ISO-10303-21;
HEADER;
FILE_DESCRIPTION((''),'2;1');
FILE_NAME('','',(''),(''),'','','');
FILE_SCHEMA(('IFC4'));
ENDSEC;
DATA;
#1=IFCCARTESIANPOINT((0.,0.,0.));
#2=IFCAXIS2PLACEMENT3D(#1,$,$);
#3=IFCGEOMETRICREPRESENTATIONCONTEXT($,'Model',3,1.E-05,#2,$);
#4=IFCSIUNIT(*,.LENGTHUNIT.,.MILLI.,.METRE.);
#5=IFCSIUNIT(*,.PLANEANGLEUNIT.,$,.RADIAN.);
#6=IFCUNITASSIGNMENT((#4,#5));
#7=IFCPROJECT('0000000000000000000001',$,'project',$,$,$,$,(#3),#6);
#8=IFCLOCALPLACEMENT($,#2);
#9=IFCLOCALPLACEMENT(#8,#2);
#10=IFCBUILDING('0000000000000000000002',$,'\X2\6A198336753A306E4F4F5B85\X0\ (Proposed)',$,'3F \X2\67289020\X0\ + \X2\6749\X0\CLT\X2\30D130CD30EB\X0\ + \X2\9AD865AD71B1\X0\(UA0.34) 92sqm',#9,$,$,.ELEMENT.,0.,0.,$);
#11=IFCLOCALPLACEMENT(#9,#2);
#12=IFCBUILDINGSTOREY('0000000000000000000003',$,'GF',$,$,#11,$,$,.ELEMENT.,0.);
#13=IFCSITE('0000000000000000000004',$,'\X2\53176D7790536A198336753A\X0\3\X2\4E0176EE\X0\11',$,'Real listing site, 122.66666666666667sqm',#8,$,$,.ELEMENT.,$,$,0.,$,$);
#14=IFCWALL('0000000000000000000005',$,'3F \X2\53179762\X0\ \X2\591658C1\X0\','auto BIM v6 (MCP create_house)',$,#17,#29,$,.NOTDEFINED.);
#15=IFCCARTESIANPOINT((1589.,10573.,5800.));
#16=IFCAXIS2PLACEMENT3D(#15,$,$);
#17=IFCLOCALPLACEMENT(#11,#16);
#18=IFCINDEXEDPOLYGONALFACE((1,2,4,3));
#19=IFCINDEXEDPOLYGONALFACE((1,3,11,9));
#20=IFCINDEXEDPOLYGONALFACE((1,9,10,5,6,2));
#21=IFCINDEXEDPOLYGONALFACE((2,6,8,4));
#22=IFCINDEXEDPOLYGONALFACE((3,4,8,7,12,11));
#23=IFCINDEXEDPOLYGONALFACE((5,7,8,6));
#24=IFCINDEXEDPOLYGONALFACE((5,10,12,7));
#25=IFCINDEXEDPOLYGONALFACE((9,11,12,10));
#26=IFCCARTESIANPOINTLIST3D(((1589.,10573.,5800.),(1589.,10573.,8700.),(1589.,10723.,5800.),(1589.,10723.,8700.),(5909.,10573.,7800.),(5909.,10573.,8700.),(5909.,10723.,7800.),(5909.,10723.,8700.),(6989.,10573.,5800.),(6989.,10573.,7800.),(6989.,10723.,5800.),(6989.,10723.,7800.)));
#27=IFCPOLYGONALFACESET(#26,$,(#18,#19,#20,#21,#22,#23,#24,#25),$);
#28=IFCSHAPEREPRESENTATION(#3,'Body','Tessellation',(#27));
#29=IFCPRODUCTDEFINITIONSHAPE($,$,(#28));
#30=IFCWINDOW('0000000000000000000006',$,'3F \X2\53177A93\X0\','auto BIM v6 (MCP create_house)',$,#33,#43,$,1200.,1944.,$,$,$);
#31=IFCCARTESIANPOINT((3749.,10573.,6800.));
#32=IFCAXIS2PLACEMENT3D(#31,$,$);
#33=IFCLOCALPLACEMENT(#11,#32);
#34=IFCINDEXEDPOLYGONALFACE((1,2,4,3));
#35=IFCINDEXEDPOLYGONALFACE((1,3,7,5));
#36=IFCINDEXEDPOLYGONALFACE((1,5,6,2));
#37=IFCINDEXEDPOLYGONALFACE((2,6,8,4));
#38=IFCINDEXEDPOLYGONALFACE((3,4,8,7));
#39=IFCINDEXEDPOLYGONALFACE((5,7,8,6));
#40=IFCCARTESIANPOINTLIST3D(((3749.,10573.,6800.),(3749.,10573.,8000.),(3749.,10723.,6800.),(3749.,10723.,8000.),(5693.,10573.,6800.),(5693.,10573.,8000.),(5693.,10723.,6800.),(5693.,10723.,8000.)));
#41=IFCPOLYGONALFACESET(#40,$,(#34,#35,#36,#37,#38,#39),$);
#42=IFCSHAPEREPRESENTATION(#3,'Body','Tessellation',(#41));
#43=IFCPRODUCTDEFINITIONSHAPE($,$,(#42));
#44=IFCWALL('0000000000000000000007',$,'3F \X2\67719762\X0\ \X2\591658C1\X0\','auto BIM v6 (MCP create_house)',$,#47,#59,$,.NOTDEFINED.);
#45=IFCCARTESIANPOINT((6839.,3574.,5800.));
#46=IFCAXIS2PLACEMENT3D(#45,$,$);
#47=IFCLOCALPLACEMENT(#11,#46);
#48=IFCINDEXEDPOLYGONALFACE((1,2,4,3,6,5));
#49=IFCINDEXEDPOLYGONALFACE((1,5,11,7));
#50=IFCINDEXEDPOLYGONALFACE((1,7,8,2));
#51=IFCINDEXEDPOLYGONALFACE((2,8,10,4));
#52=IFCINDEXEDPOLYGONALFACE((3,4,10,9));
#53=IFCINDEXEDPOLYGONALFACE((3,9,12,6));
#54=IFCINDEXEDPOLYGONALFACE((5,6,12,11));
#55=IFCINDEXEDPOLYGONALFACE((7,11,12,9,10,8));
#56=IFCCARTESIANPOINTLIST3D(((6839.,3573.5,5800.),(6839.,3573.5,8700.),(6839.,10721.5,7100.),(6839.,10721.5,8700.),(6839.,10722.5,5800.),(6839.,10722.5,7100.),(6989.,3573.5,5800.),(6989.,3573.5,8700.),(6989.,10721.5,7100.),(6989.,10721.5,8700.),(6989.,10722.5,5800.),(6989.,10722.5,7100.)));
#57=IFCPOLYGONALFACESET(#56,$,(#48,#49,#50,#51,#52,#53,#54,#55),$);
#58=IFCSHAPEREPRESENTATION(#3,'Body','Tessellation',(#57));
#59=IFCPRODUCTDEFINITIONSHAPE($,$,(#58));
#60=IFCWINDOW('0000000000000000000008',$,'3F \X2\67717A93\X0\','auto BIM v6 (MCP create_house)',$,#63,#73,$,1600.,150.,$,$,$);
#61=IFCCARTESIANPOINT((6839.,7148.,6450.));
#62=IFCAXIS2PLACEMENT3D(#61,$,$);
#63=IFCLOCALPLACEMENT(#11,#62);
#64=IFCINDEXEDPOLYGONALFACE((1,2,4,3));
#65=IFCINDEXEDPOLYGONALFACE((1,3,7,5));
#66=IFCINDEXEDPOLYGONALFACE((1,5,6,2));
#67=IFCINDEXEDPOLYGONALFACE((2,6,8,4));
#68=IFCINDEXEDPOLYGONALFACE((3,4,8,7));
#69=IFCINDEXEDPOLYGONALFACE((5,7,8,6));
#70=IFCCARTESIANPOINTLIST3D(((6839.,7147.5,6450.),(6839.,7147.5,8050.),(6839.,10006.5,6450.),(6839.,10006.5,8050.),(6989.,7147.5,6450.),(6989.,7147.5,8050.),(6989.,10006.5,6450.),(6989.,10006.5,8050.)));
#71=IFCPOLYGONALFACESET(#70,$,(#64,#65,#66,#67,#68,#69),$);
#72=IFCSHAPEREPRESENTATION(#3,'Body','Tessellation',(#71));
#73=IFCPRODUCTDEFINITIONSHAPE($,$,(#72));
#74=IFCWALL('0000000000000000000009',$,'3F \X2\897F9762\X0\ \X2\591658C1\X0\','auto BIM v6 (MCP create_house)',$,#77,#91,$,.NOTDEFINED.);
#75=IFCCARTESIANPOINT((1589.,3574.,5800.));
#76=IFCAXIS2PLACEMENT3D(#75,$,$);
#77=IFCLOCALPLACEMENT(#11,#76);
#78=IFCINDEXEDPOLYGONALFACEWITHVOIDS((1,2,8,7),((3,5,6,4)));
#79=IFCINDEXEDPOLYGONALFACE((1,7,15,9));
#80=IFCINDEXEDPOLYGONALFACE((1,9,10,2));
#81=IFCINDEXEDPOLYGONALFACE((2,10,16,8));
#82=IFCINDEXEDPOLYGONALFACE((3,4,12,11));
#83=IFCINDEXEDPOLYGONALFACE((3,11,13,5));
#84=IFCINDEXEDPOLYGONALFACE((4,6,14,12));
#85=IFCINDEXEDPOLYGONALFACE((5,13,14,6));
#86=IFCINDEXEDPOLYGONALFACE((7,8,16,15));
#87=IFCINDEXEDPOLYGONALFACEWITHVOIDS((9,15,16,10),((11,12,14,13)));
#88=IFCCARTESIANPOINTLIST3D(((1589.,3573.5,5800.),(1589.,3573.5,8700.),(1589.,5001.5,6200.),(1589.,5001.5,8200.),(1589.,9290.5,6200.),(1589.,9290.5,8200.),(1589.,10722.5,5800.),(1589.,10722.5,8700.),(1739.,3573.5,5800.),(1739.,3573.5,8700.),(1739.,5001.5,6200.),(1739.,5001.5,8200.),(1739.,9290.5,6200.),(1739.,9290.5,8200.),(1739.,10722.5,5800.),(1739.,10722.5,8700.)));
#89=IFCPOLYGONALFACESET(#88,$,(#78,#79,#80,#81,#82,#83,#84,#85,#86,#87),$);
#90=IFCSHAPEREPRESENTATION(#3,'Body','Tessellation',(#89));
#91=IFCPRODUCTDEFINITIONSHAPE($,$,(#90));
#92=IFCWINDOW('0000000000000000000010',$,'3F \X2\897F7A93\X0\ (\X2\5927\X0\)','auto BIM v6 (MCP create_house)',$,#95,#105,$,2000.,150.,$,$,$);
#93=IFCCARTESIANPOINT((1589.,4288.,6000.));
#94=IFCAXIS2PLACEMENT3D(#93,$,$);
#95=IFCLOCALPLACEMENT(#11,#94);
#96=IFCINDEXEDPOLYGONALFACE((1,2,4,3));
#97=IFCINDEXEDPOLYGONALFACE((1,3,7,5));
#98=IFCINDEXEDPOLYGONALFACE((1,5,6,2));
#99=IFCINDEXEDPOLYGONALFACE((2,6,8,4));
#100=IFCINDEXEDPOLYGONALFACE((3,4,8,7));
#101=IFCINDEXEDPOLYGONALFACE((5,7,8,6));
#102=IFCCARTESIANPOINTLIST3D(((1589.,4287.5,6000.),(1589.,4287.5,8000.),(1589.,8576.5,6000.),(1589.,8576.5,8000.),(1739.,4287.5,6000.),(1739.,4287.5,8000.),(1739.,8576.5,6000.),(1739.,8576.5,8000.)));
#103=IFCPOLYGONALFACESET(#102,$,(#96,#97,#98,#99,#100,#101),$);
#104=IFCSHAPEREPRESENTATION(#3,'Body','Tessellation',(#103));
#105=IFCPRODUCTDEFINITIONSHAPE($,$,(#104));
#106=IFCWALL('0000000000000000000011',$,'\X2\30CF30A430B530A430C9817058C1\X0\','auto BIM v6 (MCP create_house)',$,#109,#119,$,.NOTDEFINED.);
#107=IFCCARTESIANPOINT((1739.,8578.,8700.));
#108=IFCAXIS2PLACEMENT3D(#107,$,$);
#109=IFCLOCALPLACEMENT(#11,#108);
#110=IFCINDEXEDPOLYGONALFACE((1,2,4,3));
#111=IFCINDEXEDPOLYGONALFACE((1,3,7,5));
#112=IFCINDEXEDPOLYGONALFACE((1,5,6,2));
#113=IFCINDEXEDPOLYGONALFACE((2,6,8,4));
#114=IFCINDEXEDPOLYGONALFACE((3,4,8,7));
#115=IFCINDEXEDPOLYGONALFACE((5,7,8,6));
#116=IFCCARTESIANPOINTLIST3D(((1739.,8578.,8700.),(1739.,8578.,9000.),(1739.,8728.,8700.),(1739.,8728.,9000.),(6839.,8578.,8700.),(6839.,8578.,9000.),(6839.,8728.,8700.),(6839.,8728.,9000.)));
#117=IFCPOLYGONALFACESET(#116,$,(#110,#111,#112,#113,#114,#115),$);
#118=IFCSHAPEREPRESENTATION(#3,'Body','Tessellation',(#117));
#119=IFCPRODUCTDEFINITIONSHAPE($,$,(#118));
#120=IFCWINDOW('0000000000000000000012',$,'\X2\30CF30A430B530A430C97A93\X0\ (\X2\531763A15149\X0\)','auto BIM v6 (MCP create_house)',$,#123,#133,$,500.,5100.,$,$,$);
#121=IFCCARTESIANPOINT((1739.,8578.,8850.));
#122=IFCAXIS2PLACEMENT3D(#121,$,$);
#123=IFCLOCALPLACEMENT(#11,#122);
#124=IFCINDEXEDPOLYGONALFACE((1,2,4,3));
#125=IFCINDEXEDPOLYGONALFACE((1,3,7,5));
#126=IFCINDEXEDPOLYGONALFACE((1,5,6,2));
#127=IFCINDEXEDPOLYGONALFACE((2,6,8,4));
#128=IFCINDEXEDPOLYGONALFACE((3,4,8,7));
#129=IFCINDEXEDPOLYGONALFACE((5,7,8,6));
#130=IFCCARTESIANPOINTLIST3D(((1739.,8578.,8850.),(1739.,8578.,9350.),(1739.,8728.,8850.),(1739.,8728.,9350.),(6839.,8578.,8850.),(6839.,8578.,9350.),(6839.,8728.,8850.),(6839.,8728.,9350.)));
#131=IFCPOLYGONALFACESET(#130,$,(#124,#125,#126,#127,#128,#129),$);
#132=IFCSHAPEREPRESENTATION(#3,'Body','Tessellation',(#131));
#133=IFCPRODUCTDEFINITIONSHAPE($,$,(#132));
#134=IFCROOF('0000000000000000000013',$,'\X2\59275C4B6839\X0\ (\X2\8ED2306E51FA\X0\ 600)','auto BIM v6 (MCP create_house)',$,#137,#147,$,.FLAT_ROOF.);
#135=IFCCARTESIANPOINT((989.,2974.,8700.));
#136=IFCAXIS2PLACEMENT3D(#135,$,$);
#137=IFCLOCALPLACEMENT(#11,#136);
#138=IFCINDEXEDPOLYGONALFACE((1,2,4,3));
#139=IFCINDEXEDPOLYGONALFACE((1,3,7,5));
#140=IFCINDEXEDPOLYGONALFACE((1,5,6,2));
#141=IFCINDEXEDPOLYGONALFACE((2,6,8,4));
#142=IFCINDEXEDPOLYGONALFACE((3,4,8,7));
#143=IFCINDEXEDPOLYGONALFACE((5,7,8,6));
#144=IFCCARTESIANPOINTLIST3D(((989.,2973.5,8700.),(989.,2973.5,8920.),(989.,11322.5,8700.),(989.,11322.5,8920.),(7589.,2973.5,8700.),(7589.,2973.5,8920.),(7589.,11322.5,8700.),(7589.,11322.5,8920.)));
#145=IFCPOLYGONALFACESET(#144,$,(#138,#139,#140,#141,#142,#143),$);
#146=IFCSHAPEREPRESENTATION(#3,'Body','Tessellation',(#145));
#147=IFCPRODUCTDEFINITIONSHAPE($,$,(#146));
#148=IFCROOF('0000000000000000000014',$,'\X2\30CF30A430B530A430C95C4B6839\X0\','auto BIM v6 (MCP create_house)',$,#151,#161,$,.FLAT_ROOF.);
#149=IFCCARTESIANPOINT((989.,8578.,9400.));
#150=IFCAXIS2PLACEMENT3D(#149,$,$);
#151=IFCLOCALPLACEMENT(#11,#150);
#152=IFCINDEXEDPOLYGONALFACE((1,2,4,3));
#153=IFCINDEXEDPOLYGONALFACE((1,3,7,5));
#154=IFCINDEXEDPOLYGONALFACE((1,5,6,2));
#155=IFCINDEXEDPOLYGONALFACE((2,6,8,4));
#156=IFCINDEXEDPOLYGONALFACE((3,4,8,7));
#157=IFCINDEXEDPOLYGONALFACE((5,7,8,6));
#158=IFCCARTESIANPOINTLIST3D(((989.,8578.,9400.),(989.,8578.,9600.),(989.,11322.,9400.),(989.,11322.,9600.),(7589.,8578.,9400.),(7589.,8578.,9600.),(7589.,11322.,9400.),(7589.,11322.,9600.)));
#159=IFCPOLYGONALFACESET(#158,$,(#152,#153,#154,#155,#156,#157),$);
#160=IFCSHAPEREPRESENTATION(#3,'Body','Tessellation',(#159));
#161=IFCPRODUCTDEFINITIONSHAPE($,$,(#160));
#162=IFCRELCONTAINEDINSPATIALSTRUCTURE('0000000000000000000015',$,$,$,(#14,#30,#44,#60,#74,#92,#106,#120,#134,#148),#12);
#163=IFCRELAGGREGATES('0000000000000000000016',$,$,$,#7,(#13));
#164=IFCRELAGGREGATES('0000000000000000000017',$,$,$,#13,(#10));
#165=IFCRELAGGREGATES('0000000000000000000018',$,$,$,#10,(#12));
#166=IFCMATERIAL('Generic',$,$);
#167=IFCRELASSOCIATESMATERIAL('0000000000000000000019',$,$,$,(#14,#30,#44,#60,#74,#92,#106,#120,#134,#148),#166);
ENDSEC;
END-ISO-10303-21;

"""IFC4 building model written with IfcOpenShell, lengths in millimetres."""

from ifc_helpers import new_model, si_unit, frame, frame_2d, origin, place, context, project, spatial, rectangle, extrude, material, element, fill, save


model = new_model("IFC4")

# Units and contexts
model_context = context("Model", 3, precision=1e-05, world=origin())
ifc_project = project(units=[si_unit("LENGTHUNIT", "METRE", prefix="MILLI"), si_unit("PLANEANGLEUNIT", "RADIAN")], contexts=[model_context])

# Site, building, storey
site_placement = place(None, origin())
site = spatial("IfcSite", under=ifc_project, at=site_placement, Name="北海道標茶町3丁目11", ObjectType="Real listing site, 122.66666666666667sqm", CompositionType="ELEMENT", RefElevation=0.0)
building_placement = place(site_placement, origin())
building = spatial("IfcBuilding", under=site, at=building_placement, Name="標茶町の住宅 (Proposed)", ObjectType="3F 木造 + 杉CLTパネル + 高断熱(UA0.34) 92sqm", CompositionType="ELEMENT", ElevationOfRefHeight=0.0, ElevationOfTerrain=0.0)
storey_placement = place(building_placement, origin())
storey = spatial("IfcBuildingStorey", under=building, at=storey_placement, Name="GF", CompositionType="ELEMENT", Elevation=0.0)

# Shared definitions
ifc_material = material(Name="Generic")

# Walls, openings, windows
wall_1_placement = place(storey_placement, frame((1589.0, 10573.0, 5800.0)))
wall_1 = element("IfcWall", 1, at=wall_1_placement, inside=storey, material=ifc_material, Name="3F 北面 外壁", Description="auto BIM v6 (MCP create_house)", PredefinedType="NOTDEFINED", context=model_context, shape_type="SweptSolid", body=[
    extrude(rectangle(XDim=5400.0, YDim=150.0, at=frame_2d((2700.0, 75.0))), frame((1589.0, 10573.0, 5800.0)), (0.0, 0.0, 1.0), 2900.0),
])
opening_1_placement = place(storey_placement, frame((3749.0, 10573.0, 6800.0)))
opening_1 = element("IfcOpeningElement", 2, at=opening_1_placement, cuts=wall_1, PredefinedType="NOTDEFINED", context=model_context, shape_type="SweptSolid", body=[
    extrude(rectangle(XDim=1944.0, YDim=150.0, at=frame_2d((972.0, 75.0))), frame((3749.0, 10573.0, 6800.0)), (0.0, 0.0, 1.0), 1200.0),
])
window_1_placement = place(storey_placement, frame((3749.0, 10573.0, 6800.0)))
window_1 = element("IfcWindow", 3, at=window_1_placement, inside=storey, material=ifc_material, Name="3F 北窓", Description="auto BIM v6 (MCP create_house)", OverallHeight=1200.0, OverallWidth=1944.0, context=model_context, shape_type="SweptSolid", body=[
    extrude(rectangle(XDim=1944.0, YDim=150.0, at=frame_2d((972.0, 75.0))), frame((3749.0, 10573.0, 6800.0)), (0.0, 0.0, 1.0), 1200.0),
])
fill(opening_1, window_1)
wall_2_placement = place(storey_placement, frame((6839.0, 3574.0, 5800.0)))
wall_2 = element("IfcWall", 4, at=wall_2_placement, inside=storey, material=ifc_material, Name="3F 東面 外壁", Description="auto BIM v6 (MCP create_house)", PredefinedType="NOTDEFINED", context=model_context, shape_type="SweptSolid", body=[
    extrude(rectangle(XDim=150.0, YDim=7149.0, at=frame_2d((75.0, 3574.0))), frame((6839.0, 3574.0, 5800.0)), (0.0, 0.0, 1.0), 2900.0),
])
opening_2_placement = place(storey_placement, frame((6839.0, 7148.0, 6450.0)))
opening_2 = element("IfcOpeningElement", 5, at=opening_2_placement, cuts=wall_2, PredefinedType="NOTDEFINED", context=model_context, shape_type="SweptSolid", body=[
    extrude(rectangle(XDim=150.0, YDim=2859.0, at=frame_2d((75.0, 1429.0))), frame((6839.0, 7148.0, 6450.0)), (0.0, 0.0, 1.0), 1600.0),
])
window_2_placement = place(storey_placement, frame((6839.0, 7148.0, 6450.0)))
window_2 = element("IfcWindow", 6, at=window_2_placement, inside=storey, material=ifc_material, Name="3F 東窓", Description="auto BIM v6 (MCP create_house)", OverallHeight=1600.0, OverallWidth=150.0, context=model_context, shape_type="SweptSolid", body=[
    extrude(rectangle(XDim=150.0, YDim=2859.0, at=frame_2d((75.0, 1429.0))), frame((6839.0, 7148.0, 6450.0)), (0.0, 0.0, 1.0), 1600.0),
])
fill(opening_2, window_2)
wall_3_placement = place(storey_placement, frame((1589.0, 3574.0, 5800.0)))
wall_3 = element("IfcWall", 7, at=wall_3_placement, inside=storey, material=ifc_material, Name="3F 西面 外壁", Description="auto BIM v6 (MCP create_house)", PredefinedType="NOTDEFINED", context=model_context, shape_type="SweptSolid", body=[
    extrude(rectangle(XDim=150.0, YDim=7149.0, at=frame_2d((75.0, 3574.0))), frame((1589.0, 3574.0, 5800.0)), (0.0, 0.0, 1.0), 2900.0),
])
opening_3_placement = place(storey_placement, frame((1589.0, 4288.0, 6000.0)))
opening_3 = element("IfcOpeningElement", 8, at=opening_3_placement, cuts=wall_3, PredefinedType="NOTDEFINED", context=model_context, shape_type="SweptSolid", body=[
    extrude(rectangle(XDim=150.0, YDim=4289.0, at=frame_2d((75.0, 2144.0))), frame((1589.0, 4288.0, 6000.0)), (0.0, 0.0, 1.0), 2000.0),
])
window_3_placement = place(storey_placement, frame((1589.0, 4288.0, 6000.0)))
window_3 = element("IfcWindow", 9, at=window_3_placement, inside=storey, material=ifc_material, Name="3F 西窓 (大)", Description="auto BIM v6 (MCP create_house)", OverallHeight=2000.0, OverallWidth=150.0, context=model_context, shape_type="SweptSolid", body=[
    extrude(rectangle(XDim=150.0, YDim=4289.0, at=frame_2d((75.0, 2144.0))), frame((1589.0, 4288.0, 6000.0)), (0.0, 0.0, 1.0), 2000.0),
])
fill(opening_3, window_3)

# Wall, opening, window
wall_4_placement = place(storey_placement, frame((1739.0, 8578.0, 8700.0)))
wall_4 = element("IfcWall", 10, at=wall_4_placement, inside=storey, material=ifc_material, Name="ハイサイド腰壁", Description="auto BIM v6 (MCP create_house)", PredefinedType="NOTDEFINED", context=model_context, shape_type="SweptSolid", body=[
    extrude(rectangle(XDim=5100.0, YDim=150.0, at=frame_2d((2550.0, 75.0))), frame((1739.0, 8578.0, 8700.0)), (0.0, 0.0, 1.0), 700.0),
])
opening_4_placement = place(storey_placement, frame((1739.0, 8578.0, 8850.0)))
opening_4 = element("IfcOpeningElement", 11, at=opening_4_placement, cuts=wall_4, PredefinedType="NOTDEFINED", context=model_context, shape_type="SweptSolid", body=[
    extrude(rectangle(XDim=5100.0, YDim=150.0, at=frame_2d((2550.0, 75.0))), frame((1739.0, 8578.0, 8850.0)), (0.0, 0.0, 1.0), 500.0),
])
window_4_placement = place(storey_placement, frame((1739.0, 8578.0, 8850.0)))
window_4 = element("IfcWindow", 12, at=window_4_placement, inside=storey, material=ifc_material, Name="ハイサイド窓 (北採光)", Description="auto BIM v6 (MCP create_house)", OverallHeight=500.0, OverallWidth=5100.0, context=model_context, shape_type="SweptSolid", body=[
    extrude(rectangle(XDim=5100.0, YDim=150.0, at=frame_2d((2550.0, 75.0))), frame((1739.0, 8578.0, 8850.0)), (0.0, 0.0, 1.0), 500.0),
])
fill(opening_4, window_4)

# Roofs
roof_1_placement = place(storey_placement, frame((989.0, 2974.0, 8700.0)))
element("IfcRoof", 13, at=roof_1_placement, inside=storey, material=ifc_material, Name="大屋根 (軒の出 600)", Description="auto BIM v6 (MCP create_house)", PredefinedType="FLAT_ROOF", context=model_context, shape_type="SweptSolid", body=[
    extrude(rectangle(XDim=6600.0, YDim=8349.0, at=frame_2d((3300.0, 4174.0))), frame((989.0, 2974.0, 8700.0)), (0.0, 0.0, 1.0), 220.0),
])
roof_2_placement = place(storey_placement, frame((989.0, 8578.0, 9400.0)))
element("IfcRoof", 14, at=roof_2_placement, inside=storey, material=ifc_material, Name="ハイサイド屋根", Description="auto BIM v6 (MCP create_house)", PredefinedType="FLAT_ROOF", context=model_context, shape_type="SweptSolid", body=[
    extrude(rectangle(XDim=6600.0, YDim=2744.0, at=frame_2d((3300.0, 1372.0))), frame((989.0, 8578.0, 9400.0)), (0.0, 0.0, 1.0), 200.0),
])

save(model, "model.ifc")
